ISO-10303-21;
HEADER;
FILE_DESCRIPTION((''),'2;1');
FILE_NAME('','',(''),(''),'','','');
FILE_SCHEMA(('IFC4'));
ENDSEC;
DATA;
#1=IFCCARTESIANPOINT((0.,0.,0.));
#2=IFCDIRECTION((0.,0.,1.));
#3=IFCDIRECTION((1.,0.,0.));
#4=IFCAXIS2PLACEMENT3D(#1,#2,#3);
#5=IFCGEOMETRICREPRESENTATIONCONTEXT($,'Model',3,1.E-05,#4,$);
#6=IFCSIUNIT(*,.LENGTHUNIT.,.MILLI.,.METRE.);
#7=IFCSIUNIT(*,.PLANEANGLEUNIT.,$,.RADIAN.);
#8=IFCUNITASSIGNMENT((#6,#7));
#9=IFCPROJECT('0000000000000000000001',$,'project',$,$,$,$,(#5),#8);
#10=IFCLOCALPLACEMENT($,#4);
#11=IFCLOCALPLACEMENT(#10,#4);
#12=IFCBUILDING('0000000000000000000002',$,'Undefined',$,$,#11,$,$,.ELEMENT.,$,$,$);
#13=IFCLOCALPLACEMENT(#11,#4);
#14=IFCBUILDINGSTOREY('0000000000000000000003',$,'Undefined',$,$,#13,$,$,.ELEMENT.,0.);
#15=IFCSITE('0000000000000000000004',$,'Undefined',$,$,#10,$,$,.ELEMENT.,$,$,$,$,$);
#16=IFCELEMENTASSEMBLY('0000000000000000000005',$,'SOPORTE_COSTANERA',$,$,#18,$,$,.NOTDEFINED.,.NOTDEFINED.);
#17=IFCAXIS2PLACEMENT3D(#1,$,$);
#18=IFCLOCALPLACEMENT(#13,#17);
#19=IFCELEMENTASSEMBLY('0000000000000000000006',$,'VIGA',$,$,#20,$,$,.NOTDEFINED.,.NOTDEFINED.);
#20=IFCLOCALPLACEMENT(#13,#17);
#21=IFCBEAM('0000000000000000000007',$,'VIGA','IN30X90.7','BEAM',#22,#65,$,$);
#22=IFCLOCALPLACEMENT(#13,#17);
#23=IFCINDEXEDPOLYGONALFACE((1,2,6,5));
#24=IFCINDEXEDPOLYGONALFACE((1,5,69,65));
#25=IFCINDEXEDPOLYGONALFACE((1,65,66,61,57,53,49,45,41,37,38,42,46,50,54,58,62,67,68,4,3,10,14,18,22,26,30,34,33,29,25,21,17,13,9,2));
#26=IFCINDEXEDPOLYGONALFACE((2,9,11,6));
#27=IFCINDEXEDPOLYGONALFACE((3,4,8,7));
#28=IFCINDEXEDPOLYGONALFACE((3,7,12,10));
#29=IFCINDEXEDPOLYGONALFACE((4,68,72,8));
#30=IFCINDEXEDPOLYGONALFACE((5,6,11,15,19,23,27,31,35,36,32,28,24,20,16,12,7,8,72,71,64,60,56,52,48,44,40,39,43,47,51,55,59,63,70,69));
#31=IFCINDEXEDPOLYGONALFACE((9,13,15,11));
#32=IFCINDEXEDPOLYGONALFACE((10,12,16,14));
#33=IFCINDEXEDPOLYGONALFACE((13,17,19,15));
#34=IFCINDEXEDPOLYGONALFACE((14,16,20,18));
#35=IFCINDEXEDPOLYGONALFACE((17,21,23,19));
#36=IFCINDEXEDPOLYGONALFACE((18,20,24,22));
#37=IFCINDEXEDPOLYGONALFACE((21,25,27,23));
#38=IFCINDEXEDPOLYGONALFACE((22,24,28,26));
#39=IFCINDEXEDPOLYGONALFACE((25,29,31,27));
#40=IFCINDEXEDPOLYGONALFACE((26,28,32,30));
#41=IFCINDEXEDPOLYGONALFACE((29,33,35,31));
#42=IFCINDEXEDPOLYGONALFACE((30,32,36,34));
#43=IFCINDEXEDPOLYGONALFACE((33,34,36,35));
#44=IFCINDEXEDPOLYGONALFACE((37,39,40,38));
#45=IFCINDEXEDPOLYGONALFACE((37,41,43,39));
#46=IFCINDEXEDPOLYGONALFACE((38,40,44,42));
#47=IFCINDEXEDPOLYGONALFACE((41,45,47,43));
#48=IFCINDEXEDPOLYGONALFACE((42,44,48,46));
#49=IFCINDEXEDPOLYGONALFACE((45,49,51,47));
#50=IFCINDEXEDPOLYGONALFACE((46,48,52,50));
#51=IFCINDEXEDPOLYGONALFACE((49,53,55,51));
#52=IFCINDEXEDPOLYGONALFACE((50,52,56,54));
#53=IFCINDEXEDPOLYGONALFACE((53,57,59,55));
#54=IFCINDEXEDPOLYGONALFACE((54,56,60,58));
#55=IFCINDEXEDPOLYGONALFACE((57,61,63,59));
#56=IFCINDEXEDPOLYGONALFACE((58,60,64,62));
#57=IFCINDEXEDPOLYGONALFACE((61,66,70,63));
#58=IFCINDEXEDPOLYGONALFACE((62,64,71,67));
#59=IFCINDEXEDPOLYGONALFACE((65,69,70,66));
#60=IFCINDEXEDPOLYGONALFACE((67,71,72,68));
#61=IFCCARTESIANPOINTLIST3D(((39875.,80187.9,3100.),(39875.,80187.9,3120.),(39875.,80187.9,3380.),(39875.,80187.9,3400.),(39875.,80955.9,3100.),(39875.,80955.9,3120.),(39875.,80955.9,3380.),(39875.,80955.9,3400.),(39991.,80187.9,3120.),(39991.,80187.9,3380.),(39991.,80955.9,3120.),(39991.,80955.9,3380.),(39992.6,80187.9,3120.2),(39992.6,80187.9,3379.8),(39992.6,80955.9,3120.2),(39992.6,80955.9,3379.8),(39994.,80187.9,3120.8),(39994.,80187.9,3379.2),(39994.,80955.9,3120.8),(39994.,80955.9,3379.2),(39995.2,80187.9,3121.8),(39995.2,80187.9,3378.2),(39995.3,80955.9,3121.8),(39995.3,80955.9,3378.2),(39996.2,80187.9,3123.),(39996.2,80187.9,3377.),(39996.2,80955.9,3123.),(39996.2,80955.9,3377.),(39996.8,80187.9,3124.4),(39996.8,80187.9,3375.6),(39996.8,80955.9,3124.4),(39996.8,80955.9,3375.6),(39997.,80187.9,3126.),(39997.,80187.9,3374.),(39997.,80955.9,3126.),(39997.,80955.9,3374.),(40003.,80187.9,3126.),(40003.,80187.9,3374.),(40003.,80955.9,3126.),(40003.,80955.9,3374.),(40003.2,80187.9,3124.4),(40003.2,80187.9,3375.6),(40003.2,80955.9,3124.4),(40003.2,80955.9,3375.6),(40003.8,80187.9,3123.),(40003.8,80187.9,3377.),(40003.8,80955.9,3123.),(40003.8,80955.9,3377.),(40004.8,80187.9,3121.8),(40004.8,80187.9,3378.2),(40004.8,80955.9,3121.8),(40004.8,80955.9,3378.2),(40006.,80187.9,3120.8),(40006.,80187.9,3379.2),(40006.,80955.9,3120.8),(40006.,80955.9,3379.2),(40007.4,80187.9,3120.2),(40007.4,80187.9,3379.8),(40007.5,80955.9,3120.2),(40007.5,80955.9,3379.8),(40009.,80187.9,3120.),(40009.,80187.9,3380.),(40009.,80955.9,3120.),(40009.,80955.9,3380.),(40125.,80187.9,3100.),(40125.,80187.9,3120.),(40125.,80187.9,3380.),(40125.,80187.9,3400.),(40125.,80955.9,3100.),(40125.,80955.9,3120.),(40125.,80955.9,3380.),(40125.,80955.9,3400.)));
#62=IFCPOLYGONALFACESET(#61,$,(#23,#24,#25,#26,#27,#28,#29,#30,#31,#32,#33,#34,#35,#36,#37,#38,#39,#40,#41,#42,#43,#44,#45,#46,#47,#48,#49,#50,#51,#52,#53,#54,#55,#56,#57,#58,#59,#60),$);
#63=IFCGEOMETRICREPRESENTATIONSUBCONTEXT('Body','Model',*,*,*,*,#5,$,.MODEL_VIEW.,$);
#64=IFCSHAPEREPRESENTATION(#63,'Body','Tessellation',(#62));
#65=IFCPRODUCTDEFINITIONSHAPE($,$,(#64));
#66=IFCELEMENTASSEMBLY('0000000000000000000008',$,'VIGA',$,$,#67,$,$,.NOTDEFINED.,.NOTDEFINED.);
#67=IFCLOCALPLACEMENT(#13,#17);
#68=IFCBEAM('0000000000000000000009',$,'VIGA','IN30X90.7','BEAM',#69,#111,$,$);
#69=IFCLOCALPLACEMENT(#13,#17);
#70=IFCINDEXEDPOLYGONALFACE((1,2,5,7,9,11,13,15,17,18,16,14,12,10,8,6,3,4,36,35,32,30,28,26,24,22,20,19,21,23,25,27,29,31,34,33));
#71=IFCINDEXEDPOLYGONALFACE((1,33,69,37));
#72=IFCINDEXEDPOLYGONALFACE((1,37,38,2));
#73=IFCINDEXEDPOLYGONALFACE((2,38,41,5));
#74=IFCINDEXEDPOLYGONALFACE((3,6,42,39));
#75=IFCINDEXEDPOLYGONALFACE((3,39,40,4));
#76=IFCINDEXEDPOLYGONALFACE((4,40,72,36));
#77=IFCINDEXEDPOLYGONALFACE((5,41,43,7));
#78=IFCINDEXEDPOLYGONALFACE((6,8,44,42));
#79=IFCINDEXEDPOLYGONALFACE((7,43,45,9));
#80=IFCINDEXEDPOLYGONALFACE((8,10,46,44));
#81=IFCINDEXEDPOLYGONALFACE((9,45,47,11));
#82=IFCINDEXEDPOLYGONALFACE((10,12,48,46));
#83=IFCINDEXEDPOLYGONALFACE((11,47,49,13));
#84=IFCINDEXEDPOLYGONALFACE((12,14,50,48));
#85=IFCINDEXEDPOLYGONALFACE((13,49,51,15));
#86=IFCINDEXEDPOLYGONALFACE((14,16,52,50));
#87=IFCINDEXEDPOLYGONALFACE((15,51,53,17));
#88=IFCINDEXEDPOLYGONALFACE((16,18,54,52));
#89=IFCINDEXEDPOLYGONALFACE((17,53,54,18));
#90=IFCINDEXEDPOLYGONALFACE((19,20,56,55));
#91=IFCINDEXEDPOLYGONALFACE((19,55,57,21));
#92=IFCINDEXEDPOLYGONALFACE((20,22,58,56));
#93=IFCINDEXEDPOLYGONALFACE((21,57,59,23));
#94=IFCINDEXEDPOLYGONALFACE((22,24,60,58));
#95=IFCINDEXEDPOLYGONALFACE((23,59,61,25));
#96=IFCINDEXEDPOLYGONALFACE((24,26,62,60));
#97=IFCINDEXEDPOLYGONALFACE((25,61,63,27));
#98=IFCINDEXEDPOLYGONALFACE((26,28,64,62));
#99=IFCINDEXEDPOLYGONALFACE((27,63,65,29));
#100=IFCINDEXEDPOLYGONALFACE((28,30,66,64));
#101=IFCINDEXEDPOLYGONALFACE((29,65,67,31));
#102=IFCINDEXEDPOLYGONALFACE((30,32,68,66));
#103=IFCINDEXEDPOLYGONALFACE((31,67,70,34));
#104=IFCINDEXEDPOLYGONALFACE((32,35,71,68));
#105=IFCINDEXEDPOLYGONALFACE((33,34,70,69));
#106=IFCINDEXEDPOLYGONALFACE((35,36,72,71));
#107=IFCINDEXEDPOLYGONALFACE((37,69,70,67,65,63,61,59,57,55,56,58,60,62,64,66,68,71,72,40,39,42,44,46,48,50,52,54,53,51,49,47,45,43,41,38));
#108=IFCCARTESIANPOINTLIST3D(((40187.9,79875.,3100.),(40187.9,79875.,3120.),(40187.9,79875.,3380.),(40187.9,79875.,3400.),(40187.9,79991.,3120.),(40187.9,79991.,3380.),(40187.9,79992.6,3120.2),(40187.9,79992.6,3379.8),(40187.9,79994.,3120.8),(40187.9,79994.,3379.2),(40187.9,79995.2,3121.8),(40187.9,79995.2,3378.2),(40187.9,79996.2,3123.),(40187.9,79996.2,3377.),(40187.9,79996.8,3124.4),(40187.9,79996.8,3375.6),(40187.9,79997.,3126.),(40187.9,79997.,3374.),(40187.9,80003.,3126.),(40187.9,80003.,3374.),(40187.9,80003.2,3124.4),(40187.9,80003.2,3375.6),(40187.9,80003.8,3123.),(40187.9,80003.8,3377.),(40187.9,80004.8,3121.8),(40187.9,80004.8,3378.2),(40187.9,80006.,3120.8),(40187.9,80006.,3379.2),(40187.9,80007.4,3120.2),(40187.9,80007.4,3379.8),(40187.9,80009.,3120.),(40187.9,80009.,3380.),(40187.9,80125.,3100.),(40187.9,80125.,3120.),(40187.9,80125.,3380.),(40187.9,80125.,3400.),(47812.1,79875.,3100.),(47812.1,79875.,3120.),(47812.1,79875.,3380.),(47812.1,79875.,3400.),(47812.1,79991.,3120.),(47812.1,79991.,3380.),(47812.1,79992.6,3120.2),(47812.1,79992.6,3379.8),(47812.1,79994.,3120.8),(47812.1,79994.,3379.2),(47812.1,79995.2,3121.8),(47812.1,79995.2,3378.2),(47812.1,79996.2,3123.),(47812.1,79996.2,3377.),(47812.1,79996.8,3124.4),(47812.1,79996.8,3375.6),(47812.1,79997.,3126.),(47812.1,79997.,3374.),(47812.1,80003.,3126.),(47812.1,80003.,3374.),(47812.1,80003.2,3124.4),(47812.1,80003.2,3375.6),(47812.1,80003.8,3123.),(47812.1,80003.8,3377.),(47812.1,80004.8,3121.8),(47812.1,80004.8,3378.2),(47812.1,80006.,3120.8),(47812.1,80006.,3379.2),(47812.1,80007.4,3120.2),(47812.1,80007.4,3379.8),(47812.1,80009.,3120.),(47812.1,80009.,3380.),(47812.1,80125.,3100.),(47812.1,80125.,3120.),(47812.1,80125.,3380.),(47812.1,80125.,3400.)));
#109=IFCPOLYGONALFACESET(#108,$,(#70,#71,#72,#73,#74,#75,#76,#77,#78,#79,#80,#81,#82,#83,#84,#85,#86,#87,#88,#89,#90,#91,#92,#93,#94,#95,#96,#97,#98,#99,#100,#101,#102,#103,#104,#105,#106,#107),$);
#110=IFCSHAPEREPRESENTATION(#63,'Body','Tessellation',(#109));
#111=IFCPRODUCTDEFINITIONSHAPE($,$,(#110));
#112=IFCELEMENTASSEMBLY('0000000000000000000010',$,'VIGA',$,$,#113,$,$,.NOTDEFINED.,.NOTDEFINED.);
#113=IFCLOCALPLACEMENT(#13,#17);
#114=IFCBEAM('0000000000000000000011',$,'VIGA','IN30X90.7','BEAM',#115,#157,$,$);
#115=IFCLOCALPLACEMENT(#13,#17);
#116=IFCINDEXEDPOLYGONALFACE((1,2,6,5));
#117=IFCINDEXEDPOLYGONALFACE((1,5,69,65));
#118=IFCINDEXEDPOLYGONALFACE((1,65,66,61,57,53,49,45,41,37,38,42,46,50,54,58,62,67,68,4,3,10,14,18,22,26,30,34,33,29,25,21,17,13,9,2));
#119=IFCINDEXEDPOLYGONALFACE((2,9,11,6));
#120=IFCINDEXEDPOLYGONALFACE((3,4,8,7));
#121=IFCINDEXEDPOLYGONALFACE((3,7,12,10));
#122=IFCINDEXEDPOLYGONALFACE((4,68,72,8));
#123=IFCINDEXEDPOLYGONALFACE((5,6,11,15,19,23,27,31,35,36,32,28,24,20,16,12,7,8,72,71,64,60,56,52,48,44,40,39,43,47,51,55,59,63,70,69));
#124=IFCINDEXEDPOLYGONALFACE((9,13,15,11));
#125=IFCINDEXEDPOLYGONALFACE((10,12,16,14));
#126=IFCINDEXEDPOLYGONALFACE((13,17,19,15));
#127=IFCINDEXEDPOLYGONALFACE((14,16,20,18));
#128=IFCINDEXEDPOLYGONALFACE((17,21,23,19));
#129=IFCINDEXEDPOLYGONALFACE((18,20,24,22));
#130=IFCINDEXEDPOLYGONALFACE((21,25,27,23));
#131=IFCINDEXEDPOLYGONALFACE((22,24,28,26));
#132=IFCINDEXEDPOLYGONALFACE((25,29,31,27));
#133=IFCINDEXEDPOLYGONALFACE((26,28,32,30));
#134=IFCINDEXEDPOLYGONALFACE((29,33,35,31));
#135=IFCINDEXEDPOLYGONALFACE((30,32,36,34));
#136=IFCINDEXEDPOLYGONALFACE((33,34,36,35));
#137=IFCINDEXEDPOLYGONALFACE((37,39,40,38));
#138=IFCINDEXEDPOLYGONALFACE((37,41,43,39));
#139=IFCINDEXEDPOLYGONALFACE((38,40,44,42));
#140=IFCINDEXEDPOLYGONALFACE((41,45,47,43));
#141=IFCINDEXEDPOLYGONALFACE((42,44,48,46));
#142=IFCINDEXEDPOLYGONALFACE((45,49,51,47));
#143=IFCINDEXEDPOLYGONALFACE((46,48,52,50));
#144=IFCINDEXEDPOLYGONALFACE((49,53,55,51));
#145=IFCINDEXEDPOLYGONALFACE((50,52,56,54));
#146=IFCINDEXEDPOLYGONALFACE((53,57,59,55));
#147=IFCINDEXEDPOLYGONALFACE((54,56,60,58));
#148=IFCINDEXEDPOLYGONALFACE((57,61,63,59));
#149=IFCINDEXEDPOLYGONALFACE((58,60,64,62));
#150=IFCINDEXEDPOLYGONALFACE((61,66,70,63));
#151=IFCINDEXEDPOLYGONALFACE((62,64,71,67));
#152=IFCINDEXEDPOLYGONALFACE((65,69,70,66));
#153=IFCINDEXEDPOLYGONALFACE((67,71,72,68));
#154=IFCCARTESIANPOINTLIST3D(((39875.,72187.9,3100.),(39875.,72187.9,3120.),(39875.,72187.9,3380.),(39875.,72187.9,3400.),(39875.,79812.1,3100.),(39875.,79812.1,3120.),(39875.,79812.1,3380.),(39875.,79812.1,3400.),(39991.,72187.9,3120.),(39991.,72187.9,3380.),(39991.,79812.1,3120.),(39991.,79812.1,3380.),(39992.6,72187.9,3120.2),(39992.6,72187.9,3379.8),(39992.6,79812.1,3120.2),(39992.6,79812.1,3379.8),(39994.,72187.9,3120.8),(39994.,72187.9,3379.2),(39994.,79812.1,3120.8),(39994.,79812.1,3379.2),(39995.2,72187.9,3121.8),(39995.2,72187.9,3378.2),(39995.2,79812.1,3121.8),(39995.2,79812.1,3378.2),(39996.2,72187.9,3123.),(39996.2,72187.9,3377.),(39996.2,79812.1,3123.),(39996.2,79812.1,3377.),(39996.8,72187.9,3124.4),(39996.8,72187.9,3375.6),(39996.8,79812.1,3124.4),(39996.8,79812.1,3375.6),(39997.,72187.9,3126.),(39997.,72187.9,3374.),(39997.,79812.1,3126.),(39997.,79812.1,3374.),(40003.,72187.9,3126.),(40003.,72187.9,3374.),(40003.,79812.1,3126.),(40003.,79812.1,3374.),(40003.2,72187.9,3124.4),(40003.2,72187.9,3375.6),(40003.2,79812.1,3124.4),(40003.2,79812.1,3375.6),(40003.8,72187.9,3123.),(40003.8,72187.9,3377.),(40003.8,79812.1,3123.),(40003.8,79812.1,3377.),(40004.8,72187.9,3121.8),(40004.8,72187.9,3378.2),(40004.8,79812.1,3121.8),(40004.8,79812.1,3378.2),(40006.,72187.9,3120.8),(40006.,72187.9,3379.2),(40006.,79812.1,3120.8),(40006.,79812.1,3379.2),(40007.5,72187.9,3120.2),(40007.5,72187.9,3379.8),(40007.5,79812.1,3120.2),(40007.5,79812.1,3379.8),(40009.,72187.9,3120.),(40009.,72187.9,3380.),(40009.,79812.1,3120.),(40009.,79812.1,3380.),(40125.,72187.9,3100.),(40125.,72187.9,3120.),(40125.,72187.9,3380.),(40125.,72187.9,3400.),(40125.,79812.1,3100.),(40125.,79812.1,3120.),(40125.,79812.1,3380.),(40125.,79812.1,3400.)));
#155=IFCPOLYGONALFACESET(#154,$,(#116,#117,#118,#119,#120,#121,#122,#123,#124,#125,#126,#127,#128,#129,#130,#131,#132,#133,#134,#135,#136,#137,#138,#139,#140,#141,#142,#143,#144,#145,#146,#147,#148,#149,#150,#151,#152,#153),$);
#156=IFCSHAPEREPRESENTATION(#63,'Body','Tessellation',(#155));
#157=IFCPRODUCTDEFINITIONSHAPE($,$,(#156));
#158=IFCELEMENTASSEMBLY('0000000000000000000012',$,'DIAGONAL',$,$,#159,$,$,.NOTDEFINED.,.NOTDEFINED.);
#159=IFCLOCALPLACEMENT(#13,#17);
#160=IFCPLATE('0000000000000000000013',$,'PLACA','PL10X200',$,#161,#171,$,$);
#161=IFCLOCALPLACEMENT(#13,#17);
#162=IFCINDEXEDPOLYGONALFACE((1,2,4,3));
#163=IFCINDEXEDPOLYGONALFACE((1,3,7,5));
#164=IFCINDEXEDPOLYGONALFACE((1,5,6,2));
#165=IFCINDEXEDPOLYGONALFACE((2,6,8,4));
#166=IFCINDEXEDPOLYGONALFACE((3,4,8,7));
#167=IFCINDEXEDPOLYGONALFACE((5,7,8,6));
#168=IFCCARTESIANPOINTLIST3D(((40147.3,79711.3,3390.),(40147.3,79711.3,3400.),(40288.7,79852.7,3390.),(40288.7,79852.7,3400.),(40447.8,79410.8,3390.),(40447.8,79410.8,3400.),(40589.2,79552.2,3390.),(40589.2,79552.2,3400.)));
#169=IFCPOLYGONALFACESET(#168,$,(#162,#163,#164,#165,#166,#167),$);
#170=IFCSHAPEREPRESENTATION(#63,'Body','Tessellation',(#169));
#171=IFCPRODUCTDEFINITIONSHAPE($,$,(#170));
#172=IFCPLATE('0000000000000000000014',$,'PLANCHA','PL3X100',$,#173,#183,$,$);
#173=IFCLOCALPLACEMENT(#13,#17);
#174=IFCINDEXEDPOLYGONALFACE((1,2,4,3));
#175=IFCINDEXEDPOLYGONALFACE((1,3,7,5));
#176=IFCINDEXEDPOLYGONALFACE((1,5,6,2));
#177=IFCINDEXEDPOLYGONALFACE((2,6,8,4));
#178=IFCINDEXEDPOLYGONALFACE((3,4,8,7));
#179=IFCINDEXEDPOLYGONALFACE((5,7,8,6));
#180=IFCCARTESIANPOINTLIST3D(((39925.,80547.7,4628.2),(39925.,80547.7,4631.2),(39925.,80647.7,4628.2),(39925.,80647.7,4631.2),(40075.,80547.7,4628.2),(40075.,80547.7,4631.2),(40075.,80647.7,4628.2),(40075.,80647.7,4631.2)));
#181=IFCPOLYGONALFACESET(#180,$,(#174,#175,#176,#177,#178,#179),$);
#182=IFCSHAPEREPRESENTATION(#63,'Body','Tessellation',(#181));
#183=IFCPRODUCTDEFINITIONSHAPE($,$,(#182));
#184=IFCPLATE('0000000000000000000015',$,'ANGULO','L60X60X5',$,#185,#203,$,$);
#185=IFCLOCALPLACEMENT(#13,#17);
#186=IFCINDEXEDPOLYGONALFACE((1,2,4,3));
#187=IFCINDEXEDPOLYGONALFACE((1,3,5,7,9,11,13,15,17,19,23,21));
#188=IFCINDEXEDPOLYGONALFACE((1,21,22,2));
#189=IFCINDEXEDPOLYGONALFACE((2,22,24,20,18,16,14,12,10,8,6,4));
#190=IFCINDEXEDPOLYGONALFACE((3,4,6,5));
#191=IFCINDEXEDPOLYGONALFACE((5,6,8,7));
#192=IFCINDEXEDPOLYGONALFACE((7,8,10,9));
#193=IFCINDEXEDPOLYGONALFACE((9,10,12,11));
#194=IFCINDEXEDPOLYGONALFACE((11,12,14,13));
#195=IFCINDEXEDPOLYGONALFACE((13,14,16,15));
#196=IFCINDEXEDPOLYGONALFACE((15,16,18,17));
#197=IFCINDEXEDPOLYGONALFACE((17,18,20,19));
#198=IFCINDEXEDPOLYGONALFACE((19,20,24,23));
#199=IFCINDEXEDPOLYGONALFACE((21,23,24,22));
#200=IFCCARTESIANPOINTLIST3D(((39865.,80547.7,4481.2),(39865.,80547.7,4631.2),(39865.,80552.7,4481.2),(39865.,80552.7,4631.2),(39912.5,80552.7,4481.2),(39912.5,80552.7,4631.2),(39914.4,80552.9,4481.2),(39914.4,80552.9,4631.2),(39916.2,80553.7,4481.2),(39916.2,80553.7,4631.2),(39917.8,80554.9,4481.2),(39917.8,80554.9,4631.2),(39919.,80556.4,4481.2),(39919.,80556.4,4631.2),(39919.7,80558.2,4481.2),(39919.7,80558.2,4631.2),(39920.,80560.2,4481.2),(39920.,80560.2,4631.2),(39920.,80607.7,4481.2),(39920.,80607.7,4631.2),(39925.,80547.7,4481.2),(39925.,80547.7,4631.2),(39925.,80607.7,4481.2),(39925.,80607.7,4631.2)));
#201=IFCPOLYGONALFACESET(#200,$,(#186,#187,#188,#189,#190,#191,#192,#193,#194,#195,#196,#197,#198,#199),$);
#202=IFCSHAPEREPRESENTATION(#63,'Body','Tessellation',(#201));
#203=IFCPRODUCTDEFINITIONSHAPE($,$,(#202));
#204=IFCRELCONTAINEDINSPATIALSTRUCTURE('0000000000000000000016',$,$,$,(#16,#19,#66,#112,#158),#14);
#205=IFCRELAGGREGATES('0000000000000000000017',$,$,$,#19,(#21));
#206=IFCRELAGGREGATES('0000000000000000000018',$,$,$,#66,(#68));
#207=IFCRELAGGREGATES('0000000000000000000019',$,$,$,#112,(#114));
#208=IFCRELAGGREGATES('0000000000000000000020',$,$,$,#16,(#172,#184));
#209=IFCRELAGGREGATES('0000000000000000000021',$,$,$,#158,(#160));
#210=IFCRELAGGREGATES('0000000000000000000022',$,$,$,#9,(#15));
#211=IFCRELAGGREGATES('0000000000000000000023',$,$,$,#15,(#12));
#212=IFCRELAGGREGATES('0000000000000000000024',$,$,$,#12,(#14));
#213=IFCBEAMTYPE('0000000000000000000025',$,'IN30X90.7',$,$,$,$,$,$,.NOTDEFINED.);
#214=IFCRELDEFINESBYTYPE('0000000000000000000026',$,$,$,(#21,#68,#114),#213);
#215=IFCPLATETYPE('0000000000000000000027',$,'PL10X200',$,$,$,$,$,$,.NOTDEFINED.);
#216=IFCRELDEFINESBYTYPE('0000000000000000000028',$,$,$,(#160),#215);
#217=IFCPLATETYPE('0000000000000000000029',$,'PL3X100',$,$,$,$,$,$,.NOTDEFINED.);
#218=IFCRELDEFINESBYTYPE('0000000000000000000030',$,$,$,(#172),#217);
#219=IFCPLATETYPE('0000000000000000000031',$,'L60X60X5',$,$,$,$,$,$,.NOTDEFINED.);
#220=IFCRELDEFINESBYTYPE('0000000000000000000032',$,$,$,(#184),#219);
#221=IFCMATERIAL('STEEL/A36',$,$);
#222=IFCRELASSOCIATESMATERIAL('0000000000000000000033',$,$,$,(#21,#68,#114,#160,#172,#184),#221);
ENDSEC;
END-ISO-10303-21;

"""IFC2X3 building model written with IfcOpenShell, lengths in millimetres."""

from ifc_helpers import new_model, si_unit, frame, origin_with_axes, origin_2d_with_axis, place, context, subcontext, project, spatial, polyline, i_section, l_section, outline, extrude, material, type_object, element, aggregate, save


model = new_model("IFC2X3")

# Units and contexts
model_context = context("Model", 3, precision=1e-05, world=origin_with_axes())
body_context = subcontext(model_context, "Body", "Model", "MODEL_VIEW")
ifc_project = project(units=[si_unit("LENGTHUNIT", "METRE", prefix="MILLI"), si_unit("PLANEANGLEUNIT", "RADIAN")], contexts=[model_context])

# Site, building, storey
site_placement = place(None, origin_with_axes())
site = spatial("IfcSite", under=ifc_project, at=site_placement, Name="Undefined", CompositionType="ELEMENT")
building_placement = place(site_placement, origin_with_axes())
building = spatial("IfcBuilding", under=site, at=building_placement, Name="Undefined", CompositionType="ELEMENT")
storey_placement = place(building_placement, origin_with_axes())
storey = spatial("IfcBuildingStorey", under=building, at=storey_placement, Name="Undefined", CompositionType="ELEMENT", Elevation=0.0)

# Element assembly
assembly_1_placement = place(storey_placement, origin_with_axes())
assembly_1 = element("IfcElementAssembly", 1, at=assembly_1_placement, inside=storey, Name="SOPORTE_COSTANERA", AssemblyPlace="NOTDEFINED", PredefinedType="NOTDEFINED")
ifc_material_1 = material(Name="STEEL/A36")

# Element assemblies, beams
assembly_2_placement = place(storey_placement, origin_with_axes())
assembly_2 = element("IfcElementAssembly", 2, at=assembly_2_placement, inside=storey, Name="VIGA", AssemblyPlace="NOTDEFINED", PredefinedType="NOTDEFINED")
beam_type_1 = type_object("IfcBeamType", Name="IN30X90.7", PredefinedType="NOTDEFINED")
beam_1_placement = place(assembly_2_placement, frame((40000.0, 80955.9, 3250.0), z_axis=(0.0, 0.0, 1.0), x_axis=(-0.000021, -1.0, 0.0)))
beam_1 = element("IfcBeam", 3, at=beam_1_placement, type_object=beam_type_1, material=ifc_material_1, Name="VIGA", Description="IN30X90.7", ObjectType="BEAM", context=body_context, shape_type="SweptSolid", body=[
    extrude(i_section(OverallWidth=250.0, OverallDepth=300.0, WebThickness=6.0, FlangeThickness=20.0, FilletRadius=6.0, at=origin_2d_with_axis()), frame((768.0, 0.0, 0.0), z_axis=(-1.0, 0.0, 0.0), x_axis=(0.0, -1.0, 0.0)), (0.0, 0.0, 1.0), 768.0),
])
aggregate(assembly_2, [beam_1])
assembly_3_placement = place(storey_placement, origin_with_axes())
assembly_3 = element("IfcElementAssembly", 4, at=assembly_3_placement, inside=storey, Name="VIGA", AssemblyPlace="NOTDEFINED", PredefinedType="NOTDEFINED")
beam_2_placement = place(assembly_3_placement, frame((40187.9, 80000.0, 3250.0), z_axis=(0.0, 0.0, 1.0), x_axis=(1.0, 0.0, 0.0)))
beam_2 = element("IfcBeam", 5, at=beam_2_placement, type_object=beam_type_1, material=ifc_material_1, Name="VIGA", Description="IN30X90.7", ObjectType="BEAM", context=body_context, shape_type="SweptSolid", body=[
    extrude(i_section(OverallWidth=250.0, OverallDepth=300.0, WebThickness=6.0, FlangeThickness=20.0, FilletRadius=6.0, at=origin_2d_with_axis()), frame((7624.2, 0.0, 0.0), z_axis=(-1.0, 0.0, 0.0), x_axis=(0.0, -1.0, 0.0)), (0.0, 0.0, 1.0), 7624.2),
])
aggregate(assembly_3, [beam_2])
assembly_4_placement = place(storey_placement, origin_with_axes())
assembly_4 = element("IfcElementAssembly", 6, at=assembly_4_placement, inside=storey, Name="VIGA", AssemblyPlace="NOTDEFINED", PredefinedType="NOTDEFINED")
beam_3_placement = place(assembly_4_placement, frame((40000.0, 79812.1, 3250.0), z_axis=(0.0, 0.0, 1.0), x_axis=(0.0, -1.0, 0.0)))
beam_3 = element("IfcBeam", 7, at=beam_3_placement, type_object=beam_type_1, material=ifc_material_1, Name="VIGA", Description="IN30X90.7", ObjectType="BEAM", context=body_context, shape_type="SweptSolid", body=[
    extrude(i_section(OverallWidth=250.0, OverallDepth=300.0, WebThickness=6.0, FlangeThickness=20.0, FilletRadius=6.0, at=origin_2d_with_axis()), frame((7624.2, 0.0, 0.0), z_axis=(-1.0, 0.0, 0.0), x_axis=(0.0, -1.0, 0.0)), (0.0, 0.0, 1.0), 7624.2),
])
aggregate(assembly_4, [beam_3])

# Element assembly, plate
assembly_5_placement = place(storey_placement, origin_with_axes())
assembly_5 = element("IfcElementAssembly", 8, at=assembly_5_placement, inside=storey, Name="DIAGONAL", AssemblyPlace="NOTDEFINED", PredefinedType="NOTDEFINED")
plate_type_1 = type_object("IfcPlateType", Name="PL10X200", PredefinedType="NOTDEFINED")
plate_1_placement = place(assembly_5_placement, frame((40218.0, 79782.0, 3395.0), z_axis=(0.0, 0.0, -1.0), x_axis=(0.707107, -0.707107, 0.0)))
plate_1 = element("IfcPlate", 9, at=plate_1_placement, type_object=plate_type_1, material=ifc_material_1, Name="PLACA", Description="PL10X200", context=body_context, shape_type="SweptSolid", body=[
    extrude(outline(polyline([(0.0, -100.0), (0.0, 100.0), (425.0, 100.0), (425.0, -100.0), (0.0, -100.0)])), frame((0.0, 0.0, -5.0), z_axis=(0.0, 0.0, 1.0), x_axis=(1.0, 0.0, 0.0)), (0.0, 0.0, 1.0), 10.0),
])

# Plates
plate_type_2 = type_object("IfcPlateType", Name="PL3X100", PredefinedType="NOTDEFINED")
plate_2_placement = place(assembly_1_placement, frame((40075.0, 80647.7, 4629.7), z_axis=(0.0, 0.0, -1.0), x_axis=(0.0, -1.0, 0.0)))
plate_2 = element("IfcPlate", 10, at=plate_2_placement, type_object=plate_type_2, material=ifc_material_1, Name="PLANCHA", Description="PL3X100", context=body_context, shape_type="SweptSolid", body=[
    extrude(outline(polyline([(0.0, 0.0), (100.0, 0.0), (100.0, 150.0), (0.0, 150.0), (0.0, 0.0)])), frame((0.0, 0.0, -1.5), z_axis=(0.0, 0.0, 1.0), x_axis=(1.0, 0.0, 0.0)), (0.0, 0.0, 1.0), 3.0),
])
plate_type_3 = type_object("IfcPlateType", Name="L60X60X5", PredefinedType="NOTDEFINED")
plate_3_placement = place(assembly_1_placement, frame((39895.0, 80577.7, 4481.2), z_axis=(0.0, 1.0, 0.0), x_axis=(0.0, 0.0, 1.0)))
plate_3 = element("IfcPlate", 11, at=plate_3_placement, type_object=plate_type_3, material=ifc_material_1, Name="ANGULO", Description="L60X60X5", context=body_context, shape_type="SweptSolid", body=[
    extrude(l_section(Depth=60.0, Width=60.0, Thickness=5.0, FilletRadius=7.5, at=origin_2d_with_axis()), frame((150.0, 0.0, 0.0), z_axis=(-1.0, 0.0, 0.0), x_axis=(0.0, -1.0, 0.0)), (0.0, 0.0, 1.0), 150.0),
])
aggregate(assembly_1, [plate_2, plate_3])

aggregate(assembly_5, [plate_1])

save(model, "model.ifc")
